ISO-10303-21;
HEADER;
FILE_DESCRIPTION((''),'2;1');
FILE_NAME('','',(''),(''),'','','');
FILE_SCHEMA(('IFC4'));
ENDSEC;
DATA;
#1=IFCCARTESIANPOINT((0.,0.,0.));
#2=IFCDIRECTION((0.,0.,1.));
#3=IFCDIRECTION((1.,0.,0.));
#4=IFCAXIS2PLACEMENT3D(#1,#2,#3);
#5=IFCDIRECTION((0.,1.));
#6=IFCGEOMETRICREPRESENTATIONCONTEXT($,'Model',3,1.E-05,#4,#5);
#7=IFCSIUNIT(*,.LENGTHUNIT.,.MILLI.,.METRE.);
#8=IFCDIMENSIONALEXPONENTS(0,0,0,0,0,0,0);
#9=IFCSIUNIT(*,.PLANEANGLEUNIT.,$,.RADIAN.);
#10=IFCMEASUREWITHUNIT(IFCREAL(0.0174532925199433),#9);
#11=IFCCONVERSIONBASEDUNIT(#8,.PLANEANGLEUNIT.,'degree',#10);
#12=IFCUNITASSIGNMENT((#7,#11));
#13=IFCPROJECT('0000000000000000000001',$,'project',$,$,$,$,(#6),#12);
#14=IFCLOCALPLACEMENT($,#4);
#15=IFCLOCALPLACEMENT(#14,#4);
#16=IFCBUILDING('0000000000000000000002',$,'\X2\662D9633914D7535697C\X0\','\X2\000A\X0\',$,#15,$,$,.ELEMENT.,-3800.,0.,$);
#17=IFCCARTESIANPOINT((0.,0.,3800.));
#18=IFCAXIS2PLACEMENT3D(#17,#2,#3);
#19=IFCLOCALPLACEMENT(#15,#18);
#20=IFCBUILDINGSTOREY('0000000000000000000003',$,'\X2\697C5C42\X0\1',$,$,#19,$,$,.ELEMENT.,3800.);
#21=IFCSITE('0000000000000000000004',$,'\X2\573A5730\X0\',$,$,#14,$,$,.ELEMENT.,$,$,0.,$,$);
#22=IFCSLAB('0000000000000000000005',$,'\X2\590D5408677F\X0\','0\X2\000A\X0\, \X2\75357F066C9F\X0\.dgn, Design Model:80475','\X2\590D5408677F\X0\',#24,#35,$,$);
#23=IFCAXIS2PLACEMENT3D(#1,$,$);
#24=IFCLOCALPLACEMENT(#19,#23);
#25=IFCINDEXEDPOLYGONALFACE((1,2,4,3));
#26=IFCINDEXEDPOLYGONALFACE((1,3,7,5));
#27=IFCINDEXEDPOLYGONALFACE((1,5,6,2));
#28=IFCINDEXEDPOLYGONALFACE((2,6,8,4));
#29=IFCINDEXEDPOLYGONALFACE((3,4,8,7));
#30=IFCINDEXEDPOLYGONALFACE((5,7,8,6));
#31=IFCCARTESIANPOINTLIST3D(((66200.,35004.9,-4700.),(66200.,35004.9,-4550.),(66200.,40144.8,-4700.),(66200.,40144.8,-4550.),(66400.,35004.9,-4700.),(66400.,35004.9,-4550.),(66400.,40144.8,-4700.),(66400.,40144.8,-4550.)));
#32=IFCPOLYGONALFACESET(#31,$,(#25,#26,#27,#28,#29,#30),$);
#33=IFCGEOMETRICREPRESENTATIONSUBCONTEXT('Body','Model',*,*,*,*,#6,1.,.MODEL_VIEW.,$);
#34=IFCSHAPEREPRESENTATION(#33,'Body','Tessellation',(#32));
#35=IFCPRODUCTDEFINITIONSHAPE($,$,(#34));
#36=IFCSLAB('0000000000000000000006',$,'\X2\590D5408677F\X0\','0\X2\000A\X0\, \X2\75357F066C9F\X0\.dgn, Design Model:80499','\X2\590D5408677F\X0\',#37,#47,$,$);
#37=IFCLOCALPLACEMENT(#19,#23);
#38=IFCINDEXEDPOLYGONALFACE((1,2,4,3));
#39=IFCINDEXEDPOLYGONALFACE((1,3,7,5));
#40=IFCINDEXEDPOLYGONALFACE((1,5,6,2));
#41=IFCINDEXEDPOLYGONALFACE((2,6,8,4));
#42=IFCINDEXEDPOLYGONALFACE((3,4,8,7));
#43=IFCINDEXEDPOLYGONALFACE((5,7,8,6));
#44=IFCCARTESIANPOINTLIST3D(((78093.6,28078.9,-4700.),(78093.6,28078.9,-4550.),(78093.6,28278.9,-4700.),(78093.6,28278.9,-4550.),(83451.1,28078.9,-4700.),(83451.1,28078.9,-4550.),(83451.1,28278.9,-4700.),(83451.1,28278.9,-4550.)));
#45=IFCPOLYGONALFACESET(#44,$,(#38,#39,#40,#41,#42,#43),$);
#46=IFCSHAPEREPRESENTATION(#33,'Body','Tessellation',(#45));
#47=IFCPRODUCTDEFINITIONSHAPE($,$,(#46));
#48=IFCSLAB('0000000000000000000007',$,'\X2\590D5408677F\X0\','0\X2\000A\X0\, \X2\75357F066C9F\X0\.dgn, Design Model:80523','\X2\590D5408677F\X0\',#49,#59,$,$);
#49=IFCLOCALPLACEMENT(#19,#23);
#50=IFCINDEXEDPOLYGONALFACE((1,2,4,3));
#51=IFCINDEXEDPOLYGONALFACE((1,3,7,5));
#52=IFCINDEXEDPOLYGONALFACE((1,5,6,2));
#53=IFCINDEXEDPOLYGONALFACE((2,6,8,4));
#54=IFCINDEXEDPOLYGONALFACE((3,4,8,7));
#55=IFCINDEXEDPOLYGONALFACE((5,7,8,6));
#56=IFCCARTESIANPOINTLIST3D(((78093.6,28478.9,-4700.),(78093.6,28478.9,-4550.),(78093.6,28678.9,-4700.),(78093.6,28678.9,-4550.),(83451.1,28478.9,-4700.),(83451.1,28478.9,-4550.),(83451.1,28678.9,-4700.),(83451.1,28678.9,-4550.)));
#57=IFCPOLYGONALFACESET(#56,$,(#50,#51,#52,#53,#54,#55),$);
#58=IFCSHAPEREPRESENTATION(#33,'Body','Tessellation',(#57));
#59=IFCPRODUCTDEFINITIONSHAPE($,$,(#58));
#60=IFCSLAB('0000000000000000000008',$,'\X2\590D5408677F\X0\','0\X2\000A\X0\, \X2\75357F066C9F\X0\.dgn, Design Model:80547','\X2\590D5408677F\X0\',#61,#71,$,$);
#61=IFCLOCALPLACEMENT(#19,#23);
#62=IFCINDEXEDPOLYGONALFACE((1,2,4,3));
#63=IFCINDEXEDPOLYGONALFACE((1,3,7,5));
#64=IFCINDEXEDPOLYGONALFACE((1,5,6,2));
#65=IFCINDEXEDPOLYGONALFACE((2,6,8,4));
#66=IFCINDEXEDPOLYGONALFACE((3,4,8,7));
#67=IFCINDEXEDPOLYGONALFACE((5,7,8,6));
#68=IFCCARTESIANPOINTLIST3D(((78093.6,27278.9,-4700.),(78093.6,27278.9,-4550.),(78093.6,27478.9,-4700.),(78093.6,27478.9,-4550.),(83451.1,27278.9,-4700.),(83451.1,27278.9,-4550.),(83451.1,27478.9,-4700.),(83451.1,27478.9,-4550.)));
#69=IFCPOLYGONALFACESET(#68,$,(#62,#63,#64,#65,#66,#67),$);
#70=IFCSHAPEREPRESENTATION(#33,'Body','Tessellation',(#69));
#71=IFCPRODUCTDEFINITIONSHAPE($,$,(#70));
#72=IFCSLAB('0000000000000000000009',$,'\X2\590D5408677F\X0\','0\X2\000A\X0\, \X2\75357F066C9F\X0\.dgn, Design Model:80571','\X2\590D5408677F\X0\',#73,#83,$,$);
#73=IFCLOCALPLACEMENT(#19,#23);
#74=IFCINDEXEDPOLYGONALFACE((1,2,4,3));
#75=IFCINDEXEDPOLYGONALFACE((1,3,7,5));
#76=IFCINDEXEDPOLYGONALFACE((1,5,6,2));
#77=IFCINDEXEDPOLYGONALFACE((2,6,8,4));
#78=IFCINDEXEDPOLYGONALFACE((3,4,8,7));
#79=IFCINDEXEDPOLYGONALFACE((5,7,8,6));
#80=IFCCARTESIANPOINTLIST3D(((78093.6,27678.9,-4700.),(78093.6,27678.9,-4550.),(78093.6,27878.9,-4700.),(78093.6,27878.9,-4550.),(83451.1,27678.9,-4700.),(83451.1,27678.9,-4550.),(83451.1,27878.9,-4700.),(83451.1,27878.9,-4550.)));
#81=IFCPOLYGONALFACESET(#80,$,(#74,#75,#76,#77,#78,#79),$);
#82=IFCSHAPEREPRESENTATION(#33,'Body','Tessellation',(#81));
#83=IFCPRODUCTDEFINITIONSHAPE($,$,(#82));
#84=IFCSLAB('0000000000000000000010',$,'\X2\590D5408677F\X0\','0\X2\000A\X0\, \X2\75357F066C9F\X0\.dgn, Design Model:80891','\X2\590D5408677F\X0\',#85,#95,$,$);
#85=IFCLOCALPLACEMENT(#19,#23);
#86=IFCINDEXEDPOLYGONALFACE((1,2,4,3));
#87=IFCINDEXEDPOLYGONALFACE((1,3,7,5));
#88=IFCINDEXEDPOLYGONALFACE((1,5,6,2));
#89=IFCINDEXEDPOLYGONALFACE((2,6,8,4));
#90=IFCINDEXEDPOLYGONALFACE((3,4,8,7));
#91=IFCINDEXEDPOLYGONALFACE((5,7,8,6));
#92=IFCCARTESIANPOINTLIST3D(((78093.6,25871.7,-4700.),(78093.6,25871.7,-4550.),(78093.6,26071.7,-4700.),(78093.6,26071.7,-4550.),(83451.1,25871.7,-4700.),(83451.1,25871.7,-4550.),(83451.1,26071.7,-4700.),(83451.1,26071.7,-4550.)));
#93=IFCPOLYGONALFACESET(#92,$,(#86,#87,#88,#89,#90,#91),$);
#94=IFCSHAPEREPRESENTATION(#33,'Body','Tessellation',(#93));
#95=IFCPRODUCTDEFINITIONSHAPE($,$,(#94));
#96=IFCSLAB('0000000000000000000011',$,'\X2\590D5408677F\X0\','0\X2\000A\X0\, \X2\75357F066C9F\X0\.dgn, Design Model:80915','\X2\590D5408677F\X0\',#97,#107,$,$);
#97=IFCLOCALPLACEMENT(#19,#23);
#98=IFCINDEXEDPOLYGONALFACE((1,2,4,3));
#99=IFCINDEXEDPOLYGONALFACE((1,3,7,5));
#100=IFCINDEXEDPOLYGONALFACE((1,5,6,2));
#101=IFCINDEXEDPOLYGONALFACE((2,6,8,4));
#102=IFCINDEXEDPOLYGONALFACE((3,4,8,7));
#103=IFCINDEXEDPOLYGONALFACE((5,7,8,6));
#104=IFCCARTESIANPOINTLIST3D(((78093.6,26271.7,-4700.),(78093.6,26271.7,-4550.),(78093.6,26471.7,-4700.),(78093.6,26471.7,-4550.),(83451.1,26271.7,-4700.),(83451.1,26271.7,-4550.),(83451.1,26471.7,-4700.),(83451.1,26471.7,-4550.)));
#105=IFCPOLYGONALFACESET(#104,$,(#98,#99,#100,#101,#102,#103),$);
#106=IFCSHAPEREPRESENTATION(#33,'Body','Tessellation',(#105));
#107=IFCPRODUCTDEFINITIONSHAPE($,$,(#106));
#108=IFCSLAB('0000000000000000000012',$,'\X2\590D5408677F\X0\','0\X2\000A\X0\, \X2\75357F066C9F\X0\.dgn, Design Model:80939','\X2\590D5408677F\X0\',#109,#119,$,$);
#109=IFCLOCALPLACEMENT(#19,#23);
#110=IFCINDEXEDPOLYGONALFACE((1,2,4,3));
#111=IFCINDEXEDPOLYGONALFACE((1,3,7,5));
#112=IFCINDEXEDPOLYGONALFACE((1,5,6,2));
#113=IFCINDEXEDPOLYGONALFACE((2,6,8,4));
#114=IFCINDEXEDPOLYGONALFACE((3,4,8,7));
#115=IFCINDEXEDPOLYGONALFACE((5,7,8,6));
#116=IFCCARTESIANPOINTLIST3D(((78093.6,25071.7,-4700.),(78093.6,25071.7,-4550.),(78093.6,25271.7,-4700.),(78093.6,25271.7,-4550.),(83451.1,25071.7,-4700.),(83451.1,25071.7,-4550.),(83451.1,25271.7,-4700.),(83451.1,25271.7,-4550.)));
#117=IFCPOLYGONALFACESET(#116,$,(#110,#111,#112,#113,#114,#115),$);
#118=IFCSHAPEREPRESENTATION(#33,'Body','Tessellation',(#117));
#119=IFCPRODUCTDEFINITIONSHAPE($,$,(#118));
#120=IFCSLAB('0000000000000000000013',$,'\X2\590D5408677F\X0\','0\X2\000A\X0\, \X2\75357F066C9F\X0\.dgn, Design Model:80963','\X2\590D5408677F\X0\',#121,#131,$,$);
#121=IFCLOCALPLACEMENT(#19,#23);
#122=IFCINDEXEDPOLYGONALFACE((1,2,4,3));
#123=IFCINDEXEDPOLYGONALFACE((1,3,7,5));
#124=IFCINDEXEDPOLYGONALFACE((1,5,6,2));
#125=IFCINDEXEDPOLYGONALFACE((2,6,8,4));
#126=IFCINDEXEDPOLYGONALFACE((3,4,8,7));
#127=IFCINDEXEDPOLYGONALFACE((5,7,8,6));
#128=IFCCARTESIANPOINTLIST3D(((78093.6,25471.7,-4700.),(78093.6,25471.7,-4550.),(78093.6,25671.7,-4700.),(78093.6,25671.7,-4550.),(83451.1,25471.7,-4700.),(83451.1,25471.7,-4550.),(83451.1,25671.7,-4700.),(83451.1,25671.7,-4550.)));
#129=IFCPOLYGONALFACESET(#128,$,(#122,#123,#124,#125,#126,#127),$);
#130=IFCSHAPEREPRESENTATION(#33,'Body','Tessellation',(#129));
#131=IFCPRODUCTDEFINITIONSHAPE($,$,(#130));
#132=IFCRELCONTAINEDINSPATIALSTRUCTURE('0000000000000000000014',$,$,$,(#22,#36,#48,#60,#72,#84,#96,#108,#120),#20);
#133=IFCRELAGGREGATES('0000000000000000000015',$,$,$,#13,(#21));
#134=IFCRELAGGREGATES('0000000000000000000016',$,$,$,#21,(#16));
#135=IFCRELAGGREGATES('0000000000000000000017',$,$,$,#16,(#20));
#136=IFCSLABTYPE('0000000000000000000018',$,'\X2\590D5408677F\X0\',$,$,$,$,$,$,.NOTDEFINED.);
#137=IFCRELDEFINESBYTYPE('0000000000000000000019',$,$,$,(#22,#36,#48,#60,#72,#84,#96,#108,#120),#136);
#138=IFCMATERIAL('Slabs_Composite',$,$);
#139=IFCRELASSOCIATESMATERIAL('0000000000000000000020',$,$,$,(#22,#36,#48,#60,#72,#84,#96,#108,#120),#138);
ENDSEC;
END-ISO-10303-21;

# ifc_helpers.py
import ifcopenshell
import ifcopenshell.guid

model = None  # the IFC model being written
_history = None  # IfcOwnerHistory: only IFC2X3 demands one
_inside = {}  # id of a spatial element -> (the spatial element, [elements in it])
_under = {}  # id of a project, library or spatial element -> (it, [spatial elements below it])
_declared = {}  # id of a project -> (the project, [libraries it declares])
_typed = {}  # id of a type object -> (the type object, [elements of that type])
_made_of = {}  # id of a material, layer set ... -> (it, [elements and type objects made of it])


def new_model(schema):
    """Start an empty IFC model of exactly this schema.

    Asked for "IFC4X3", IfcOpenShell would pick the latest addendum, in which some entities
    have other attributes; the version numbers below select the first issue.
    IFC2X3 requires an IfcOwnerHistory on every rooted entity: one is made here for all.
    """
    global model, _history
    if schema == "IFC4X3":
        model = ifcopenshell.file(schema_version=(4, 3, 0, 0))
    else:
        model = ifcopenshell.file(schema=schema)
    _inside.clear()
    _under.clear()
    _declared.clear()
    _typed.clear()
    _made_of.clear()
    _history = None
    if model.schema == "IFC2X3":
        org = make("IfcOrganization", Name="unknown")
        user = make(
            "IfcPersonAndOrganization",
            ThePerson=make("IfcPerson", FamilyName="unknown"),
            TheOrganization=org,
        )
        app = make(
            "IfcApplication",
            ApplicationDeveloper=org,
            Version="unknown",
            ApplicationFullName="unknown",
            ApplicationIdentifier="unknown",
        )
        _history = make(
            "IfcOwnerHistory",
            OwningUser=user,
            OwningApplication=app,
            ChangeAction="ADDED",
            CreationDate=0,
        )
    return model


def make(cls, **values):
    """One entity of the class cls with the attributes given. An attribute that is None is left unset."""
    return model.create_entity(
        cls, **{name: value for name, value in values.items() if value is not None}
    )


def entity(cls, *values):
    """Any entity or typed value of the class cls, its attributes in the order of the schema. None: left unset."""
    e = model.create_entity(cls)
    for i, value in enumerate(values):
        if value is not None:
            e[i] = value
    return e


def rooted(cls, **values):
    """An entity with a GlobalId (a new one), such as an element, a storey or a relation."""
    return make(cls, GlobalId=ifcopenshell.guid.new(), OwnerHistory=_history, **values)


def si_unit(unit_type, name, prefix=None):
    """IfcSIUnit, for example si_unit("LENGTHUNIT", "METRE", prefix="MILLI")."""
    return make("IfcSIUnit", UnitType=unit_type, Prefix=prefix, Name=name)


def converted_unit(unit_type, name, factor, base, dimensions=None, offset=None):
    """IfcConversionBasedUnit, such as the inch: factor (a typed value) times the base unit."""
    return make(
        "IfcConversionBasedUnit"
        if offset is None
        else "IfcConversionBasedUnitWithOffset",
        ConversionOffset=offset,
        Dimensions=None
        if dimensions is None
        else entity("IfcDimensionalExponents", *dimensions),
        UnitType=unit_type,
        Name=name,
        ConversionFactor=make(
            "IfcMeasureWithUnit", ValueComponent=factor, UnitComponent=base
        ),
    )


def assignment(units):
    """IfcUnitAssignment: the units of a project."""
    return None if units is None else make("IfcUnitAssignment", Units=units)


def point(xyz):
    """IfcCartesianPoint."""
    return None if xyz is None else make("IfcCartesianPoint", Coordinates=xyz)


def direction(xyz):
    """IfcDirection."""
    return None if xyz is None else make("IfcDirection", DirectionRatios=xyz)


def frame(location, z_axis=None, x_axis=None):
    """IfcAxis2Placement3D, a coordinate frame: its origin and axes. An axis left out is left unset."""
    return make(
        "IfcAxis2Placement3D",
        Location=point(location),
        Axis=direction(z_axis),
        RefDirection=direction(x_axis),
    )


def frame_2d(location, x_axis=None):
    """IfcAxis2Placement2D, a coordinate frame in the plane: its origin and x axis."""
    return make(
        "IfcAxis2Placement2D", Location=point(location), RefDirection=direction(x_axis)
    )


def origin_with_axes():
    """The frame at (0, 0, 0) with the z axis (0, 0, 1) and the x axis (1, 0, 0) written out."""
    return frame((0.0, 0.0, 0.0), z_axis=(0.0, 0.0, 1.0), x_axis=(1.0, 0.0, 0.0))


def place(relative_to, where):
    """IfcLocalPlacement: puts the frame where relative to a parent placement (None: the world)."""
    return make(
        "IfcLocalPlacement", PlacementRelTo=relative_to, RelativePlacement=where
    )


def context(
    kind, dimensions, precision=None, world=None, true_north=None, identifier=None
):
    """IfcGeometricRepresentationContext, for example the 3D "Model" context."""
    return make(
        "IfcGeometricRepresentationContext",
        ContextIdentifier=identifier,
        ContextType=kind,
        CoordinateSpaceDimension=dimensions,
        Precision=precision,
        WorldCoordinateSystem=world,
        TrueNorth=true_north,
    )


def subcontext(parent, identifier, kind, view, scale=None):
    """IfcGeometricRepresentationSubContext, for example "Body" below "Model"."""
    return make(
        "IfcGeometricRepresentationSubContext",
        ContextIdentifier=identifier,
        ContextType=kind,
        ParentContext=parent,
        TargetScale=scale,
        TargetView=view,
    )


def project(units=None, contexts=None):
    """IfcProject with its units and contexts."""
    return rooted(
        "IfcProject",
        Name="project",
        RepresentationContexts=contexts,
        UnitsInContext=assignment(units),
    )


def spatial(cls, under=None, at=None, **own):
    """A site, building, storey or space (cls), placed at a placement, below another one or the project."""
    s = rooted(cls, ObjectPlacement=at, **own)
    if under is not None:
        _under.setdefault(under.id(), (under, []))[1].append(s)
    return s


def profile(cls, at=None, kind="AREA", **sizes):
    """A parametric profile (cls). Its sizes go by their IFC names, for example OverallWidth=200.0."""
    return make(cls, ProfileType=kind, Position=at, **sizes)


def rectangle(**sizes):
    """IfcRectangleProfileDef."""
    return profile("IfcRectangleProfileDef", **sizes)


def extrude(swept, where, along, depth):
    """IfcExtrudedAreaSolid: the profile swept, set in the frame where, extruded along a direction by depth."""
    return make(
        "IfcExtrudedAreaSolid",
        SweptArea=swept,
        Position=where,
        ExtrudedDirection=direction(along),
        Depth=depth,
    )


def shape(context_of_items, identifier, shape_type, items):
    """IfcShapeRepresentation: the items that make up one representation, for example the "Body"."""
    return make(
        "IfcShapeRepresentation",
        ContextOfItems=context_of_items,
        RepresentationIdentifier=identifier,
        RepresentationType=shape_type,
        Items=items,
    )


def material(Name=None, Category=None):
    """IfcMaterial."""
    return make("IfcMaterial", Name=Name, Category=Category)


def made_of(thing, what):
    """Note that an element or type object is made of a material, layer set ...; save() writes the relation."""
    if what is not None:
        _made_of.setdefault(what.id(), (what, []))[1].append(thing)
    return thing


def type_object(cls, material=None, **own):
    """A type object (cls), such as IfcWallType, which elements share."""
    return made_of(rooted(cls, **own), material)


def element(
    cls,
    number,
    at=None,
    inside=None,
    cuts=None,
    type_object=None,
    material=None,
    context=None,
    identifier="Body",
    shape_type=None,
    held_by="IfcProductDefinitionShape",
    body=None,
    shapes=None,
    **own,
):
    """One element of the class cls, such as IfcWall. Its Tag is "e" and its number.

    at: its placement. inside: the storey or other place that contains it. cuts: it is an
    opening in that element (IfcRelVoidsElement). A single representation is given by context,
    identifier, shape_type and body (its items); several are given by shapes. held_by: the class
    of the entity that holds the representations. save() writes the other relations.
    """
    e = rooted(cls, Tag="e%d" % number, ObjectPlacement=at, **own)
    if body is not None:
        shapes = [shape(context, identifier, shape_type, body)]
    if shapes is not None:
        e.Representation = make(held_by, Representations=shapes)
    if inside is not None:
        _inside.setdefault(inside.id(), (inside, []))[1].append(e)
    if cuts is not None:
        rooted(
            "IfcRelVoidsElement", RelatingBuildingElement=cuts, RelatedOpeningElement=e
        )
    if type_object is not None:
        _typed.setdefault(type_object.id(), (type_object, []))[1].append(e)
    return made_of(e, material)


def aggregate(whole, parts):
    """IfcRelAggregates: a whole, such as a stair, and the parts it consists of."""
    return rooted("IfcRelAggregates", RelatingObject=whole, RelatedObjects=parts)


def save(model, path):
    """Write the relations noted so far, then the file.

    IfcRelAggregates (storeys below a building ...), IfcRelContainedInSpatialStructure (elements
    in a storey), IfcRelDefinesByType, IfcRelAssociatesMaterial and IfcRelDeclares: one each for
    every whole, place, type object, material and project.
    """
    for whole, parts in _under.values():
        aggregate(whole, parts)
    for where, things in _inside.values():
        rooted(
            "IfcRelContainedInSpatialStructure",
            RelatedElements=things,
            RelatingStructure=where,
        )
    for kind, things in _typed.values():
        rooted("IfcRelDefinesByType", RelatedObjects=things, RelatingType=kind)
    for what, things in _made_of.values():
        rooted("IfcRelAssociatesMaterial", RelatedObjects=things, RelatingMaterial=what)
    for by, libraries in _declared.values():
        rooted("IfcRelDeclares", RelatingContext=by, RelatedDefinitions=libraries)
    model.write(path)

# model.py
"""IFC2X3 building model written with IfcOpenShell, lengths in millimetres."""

from ifc_helpers import new_model, entity, si_unit, converted_unit, direction, frame, frame_2d, origin_with_axes, place, context, subcontext, project, spatial, rectangle, extrude, material, type_object, element, save


model = new_model("IFC2X3")

# Units and contexts
model_context = context("Model", 3, precision=1e-05, world=origin_with_axes(), true_north=direction((0.0, 1.0)))
body_context = subcontext(model_context, "Body", "Model", "MODEL_VIEW", scale=1.0)
ifc_project = project(units=[si_unit("LENGTHUNIT", "METRE", prefix="MILLI"), converted_unit("PLANEANGLEUNIT", "degree", entity("IfcReal", 0.0174532925199433), si_unit("PLANEANGLEUNIT", "RADIAN"), dimensions=[0, 0, 0, 0, 0, 0, 0])], contexts=[model_context])

# Site, building, storey
site_placement = place(None, origin_with_axes())
site = spatial("IfcSite", under=ifc_project, at=site_placement, Name="场地", CompositionType="ELEMENT", RefElevation=0.0)
building_placement = place(site_placement, origin_with_axes())
building = spatial("IfcBuilding", under=site, at=building_placement, Name="昭阳配电楼", Description="\n", CompositionType="ELEMENT", ElevationOfRefHeight=-3800.0, ElevationOfTerrain=0.0)
storey_placement = place(building_placement, frame((0.0, 0.0, 3800.0), z_axis=(0.0, 0.0, 1.0), x_axis=(1.0, 0.0, 0.0)))
storey = spatial("IfcBuildingStorey", under=building, at=storey_placement, Name="楼层1", CompositionType="ELEMENT", Elevation=3800.0)

# Slabs
ifc_material = material(Name="Slabs_Composite")
slab_type = type_object("IfcSlabType", Name="复合板", PredefinedType="NOTDEFINED")
for number, where, z_axis, x_axis, name in (
    (1, (66200.0, 40144.8, -4550.0), (0.0, 0.0, -1.0), (1.0, 0.0, 0.0), "复合板"),
):
    element("IfcSlab", number, at=place(storey_placement, frame(where, z_axis=z_axis, x_axis=x_axis)), inside=storey, type_object=slab_type, material=ifc_material, Name=name, Description="0\n, 电缆沟.dgn, Design Model:80475", ObjectType="复合板", context=body_context, shape_type="SweptSolid", body=[
        extrude(rectangle(XDim=200.0, YDim=5139.9, at=frame_2d((100.0, 2570.0), x_axis=(1.0, 0.0))), origin_with_axes(), (0.0, 0.0, 1.0), 150.0),
    ])
for number, where, z_axis, x_axis, name, description in (
    (2, (83451.1, 28278.9, -4550.0), (0.0, 0.0, -1.0), (0.0, -1.0, 0.0), "复合板", "0\n, 电缆沟.dgn, Design Model:80499"),
    (3, (83451.1, 28678.9, -4550.0), (0.0, 0.0, -1.0), (0.0, -1.0, 0.0), "复合板", "0\n, 电缆沟.dgn, Design Model:80523"),
    (4, (83451.1, 27478.9, -4550.0), (0.0, 0.0, -1.0), (0.0, -1.0, 0.0), "复合板", "0\n, 电缆沟.dgn, Design Model:80547"),
    (5, (83451.1, 27878.9, -4550.0), (0.0, 0.0, -1.0), (0.0, -1.0, 0.0), "复合板", "0\n, 电缆沟.dgn, Design Model:80571"),
    (6, (83451.1, 26071.7, -4550.0), (0.0, 0.0, -1.0), (0.0, -1.0, 0.0), "复合板", "0\n, 电缆沟.dgn, Design Model:80891"),
    (7, (83451.1, 26471.7, -4550.0), (0.0, 0.0, -1.0), (0.0, -1.0, 0.0), "复合板", "0\n, 电缆沟.dgn, Design Model:80915"),
    (8, (83451.1, 25271.7, -4550.0), (0.0, 0.0, -1.0), (0.0, -1.0, 0.0), "复合板", "0\n, 电缆沟.dgn, Design Model:80939"),
    (9, (83451.1, 25671.7, -4550.0), (0.0, 0.0, -1.0), (0.0, -1.0, 0.0), "复合板", "0\n, 电缆沟.dgn, Design Model:80963"),
):
    element("IfcSlab", number, at=place(storey_placement, frame(where, z_axis=z_axis, x_axis=x_axis)), inside=storey, type_object=slab_type, material=ifc_material, Name=name, Description=description, ObjectType="复合板", context=body_context, shape_type="SweptSolid", body=[
        extrude(rectangle(XDim=200.0, YDim=5357.6, at=frame_2d((100.0, 2678.8), x_axis=(1.0, 0.0))), origin_with_axes(), (0.0, 0.0, 1.0), 150.0),
    ])

save(model, "model.ifc")
